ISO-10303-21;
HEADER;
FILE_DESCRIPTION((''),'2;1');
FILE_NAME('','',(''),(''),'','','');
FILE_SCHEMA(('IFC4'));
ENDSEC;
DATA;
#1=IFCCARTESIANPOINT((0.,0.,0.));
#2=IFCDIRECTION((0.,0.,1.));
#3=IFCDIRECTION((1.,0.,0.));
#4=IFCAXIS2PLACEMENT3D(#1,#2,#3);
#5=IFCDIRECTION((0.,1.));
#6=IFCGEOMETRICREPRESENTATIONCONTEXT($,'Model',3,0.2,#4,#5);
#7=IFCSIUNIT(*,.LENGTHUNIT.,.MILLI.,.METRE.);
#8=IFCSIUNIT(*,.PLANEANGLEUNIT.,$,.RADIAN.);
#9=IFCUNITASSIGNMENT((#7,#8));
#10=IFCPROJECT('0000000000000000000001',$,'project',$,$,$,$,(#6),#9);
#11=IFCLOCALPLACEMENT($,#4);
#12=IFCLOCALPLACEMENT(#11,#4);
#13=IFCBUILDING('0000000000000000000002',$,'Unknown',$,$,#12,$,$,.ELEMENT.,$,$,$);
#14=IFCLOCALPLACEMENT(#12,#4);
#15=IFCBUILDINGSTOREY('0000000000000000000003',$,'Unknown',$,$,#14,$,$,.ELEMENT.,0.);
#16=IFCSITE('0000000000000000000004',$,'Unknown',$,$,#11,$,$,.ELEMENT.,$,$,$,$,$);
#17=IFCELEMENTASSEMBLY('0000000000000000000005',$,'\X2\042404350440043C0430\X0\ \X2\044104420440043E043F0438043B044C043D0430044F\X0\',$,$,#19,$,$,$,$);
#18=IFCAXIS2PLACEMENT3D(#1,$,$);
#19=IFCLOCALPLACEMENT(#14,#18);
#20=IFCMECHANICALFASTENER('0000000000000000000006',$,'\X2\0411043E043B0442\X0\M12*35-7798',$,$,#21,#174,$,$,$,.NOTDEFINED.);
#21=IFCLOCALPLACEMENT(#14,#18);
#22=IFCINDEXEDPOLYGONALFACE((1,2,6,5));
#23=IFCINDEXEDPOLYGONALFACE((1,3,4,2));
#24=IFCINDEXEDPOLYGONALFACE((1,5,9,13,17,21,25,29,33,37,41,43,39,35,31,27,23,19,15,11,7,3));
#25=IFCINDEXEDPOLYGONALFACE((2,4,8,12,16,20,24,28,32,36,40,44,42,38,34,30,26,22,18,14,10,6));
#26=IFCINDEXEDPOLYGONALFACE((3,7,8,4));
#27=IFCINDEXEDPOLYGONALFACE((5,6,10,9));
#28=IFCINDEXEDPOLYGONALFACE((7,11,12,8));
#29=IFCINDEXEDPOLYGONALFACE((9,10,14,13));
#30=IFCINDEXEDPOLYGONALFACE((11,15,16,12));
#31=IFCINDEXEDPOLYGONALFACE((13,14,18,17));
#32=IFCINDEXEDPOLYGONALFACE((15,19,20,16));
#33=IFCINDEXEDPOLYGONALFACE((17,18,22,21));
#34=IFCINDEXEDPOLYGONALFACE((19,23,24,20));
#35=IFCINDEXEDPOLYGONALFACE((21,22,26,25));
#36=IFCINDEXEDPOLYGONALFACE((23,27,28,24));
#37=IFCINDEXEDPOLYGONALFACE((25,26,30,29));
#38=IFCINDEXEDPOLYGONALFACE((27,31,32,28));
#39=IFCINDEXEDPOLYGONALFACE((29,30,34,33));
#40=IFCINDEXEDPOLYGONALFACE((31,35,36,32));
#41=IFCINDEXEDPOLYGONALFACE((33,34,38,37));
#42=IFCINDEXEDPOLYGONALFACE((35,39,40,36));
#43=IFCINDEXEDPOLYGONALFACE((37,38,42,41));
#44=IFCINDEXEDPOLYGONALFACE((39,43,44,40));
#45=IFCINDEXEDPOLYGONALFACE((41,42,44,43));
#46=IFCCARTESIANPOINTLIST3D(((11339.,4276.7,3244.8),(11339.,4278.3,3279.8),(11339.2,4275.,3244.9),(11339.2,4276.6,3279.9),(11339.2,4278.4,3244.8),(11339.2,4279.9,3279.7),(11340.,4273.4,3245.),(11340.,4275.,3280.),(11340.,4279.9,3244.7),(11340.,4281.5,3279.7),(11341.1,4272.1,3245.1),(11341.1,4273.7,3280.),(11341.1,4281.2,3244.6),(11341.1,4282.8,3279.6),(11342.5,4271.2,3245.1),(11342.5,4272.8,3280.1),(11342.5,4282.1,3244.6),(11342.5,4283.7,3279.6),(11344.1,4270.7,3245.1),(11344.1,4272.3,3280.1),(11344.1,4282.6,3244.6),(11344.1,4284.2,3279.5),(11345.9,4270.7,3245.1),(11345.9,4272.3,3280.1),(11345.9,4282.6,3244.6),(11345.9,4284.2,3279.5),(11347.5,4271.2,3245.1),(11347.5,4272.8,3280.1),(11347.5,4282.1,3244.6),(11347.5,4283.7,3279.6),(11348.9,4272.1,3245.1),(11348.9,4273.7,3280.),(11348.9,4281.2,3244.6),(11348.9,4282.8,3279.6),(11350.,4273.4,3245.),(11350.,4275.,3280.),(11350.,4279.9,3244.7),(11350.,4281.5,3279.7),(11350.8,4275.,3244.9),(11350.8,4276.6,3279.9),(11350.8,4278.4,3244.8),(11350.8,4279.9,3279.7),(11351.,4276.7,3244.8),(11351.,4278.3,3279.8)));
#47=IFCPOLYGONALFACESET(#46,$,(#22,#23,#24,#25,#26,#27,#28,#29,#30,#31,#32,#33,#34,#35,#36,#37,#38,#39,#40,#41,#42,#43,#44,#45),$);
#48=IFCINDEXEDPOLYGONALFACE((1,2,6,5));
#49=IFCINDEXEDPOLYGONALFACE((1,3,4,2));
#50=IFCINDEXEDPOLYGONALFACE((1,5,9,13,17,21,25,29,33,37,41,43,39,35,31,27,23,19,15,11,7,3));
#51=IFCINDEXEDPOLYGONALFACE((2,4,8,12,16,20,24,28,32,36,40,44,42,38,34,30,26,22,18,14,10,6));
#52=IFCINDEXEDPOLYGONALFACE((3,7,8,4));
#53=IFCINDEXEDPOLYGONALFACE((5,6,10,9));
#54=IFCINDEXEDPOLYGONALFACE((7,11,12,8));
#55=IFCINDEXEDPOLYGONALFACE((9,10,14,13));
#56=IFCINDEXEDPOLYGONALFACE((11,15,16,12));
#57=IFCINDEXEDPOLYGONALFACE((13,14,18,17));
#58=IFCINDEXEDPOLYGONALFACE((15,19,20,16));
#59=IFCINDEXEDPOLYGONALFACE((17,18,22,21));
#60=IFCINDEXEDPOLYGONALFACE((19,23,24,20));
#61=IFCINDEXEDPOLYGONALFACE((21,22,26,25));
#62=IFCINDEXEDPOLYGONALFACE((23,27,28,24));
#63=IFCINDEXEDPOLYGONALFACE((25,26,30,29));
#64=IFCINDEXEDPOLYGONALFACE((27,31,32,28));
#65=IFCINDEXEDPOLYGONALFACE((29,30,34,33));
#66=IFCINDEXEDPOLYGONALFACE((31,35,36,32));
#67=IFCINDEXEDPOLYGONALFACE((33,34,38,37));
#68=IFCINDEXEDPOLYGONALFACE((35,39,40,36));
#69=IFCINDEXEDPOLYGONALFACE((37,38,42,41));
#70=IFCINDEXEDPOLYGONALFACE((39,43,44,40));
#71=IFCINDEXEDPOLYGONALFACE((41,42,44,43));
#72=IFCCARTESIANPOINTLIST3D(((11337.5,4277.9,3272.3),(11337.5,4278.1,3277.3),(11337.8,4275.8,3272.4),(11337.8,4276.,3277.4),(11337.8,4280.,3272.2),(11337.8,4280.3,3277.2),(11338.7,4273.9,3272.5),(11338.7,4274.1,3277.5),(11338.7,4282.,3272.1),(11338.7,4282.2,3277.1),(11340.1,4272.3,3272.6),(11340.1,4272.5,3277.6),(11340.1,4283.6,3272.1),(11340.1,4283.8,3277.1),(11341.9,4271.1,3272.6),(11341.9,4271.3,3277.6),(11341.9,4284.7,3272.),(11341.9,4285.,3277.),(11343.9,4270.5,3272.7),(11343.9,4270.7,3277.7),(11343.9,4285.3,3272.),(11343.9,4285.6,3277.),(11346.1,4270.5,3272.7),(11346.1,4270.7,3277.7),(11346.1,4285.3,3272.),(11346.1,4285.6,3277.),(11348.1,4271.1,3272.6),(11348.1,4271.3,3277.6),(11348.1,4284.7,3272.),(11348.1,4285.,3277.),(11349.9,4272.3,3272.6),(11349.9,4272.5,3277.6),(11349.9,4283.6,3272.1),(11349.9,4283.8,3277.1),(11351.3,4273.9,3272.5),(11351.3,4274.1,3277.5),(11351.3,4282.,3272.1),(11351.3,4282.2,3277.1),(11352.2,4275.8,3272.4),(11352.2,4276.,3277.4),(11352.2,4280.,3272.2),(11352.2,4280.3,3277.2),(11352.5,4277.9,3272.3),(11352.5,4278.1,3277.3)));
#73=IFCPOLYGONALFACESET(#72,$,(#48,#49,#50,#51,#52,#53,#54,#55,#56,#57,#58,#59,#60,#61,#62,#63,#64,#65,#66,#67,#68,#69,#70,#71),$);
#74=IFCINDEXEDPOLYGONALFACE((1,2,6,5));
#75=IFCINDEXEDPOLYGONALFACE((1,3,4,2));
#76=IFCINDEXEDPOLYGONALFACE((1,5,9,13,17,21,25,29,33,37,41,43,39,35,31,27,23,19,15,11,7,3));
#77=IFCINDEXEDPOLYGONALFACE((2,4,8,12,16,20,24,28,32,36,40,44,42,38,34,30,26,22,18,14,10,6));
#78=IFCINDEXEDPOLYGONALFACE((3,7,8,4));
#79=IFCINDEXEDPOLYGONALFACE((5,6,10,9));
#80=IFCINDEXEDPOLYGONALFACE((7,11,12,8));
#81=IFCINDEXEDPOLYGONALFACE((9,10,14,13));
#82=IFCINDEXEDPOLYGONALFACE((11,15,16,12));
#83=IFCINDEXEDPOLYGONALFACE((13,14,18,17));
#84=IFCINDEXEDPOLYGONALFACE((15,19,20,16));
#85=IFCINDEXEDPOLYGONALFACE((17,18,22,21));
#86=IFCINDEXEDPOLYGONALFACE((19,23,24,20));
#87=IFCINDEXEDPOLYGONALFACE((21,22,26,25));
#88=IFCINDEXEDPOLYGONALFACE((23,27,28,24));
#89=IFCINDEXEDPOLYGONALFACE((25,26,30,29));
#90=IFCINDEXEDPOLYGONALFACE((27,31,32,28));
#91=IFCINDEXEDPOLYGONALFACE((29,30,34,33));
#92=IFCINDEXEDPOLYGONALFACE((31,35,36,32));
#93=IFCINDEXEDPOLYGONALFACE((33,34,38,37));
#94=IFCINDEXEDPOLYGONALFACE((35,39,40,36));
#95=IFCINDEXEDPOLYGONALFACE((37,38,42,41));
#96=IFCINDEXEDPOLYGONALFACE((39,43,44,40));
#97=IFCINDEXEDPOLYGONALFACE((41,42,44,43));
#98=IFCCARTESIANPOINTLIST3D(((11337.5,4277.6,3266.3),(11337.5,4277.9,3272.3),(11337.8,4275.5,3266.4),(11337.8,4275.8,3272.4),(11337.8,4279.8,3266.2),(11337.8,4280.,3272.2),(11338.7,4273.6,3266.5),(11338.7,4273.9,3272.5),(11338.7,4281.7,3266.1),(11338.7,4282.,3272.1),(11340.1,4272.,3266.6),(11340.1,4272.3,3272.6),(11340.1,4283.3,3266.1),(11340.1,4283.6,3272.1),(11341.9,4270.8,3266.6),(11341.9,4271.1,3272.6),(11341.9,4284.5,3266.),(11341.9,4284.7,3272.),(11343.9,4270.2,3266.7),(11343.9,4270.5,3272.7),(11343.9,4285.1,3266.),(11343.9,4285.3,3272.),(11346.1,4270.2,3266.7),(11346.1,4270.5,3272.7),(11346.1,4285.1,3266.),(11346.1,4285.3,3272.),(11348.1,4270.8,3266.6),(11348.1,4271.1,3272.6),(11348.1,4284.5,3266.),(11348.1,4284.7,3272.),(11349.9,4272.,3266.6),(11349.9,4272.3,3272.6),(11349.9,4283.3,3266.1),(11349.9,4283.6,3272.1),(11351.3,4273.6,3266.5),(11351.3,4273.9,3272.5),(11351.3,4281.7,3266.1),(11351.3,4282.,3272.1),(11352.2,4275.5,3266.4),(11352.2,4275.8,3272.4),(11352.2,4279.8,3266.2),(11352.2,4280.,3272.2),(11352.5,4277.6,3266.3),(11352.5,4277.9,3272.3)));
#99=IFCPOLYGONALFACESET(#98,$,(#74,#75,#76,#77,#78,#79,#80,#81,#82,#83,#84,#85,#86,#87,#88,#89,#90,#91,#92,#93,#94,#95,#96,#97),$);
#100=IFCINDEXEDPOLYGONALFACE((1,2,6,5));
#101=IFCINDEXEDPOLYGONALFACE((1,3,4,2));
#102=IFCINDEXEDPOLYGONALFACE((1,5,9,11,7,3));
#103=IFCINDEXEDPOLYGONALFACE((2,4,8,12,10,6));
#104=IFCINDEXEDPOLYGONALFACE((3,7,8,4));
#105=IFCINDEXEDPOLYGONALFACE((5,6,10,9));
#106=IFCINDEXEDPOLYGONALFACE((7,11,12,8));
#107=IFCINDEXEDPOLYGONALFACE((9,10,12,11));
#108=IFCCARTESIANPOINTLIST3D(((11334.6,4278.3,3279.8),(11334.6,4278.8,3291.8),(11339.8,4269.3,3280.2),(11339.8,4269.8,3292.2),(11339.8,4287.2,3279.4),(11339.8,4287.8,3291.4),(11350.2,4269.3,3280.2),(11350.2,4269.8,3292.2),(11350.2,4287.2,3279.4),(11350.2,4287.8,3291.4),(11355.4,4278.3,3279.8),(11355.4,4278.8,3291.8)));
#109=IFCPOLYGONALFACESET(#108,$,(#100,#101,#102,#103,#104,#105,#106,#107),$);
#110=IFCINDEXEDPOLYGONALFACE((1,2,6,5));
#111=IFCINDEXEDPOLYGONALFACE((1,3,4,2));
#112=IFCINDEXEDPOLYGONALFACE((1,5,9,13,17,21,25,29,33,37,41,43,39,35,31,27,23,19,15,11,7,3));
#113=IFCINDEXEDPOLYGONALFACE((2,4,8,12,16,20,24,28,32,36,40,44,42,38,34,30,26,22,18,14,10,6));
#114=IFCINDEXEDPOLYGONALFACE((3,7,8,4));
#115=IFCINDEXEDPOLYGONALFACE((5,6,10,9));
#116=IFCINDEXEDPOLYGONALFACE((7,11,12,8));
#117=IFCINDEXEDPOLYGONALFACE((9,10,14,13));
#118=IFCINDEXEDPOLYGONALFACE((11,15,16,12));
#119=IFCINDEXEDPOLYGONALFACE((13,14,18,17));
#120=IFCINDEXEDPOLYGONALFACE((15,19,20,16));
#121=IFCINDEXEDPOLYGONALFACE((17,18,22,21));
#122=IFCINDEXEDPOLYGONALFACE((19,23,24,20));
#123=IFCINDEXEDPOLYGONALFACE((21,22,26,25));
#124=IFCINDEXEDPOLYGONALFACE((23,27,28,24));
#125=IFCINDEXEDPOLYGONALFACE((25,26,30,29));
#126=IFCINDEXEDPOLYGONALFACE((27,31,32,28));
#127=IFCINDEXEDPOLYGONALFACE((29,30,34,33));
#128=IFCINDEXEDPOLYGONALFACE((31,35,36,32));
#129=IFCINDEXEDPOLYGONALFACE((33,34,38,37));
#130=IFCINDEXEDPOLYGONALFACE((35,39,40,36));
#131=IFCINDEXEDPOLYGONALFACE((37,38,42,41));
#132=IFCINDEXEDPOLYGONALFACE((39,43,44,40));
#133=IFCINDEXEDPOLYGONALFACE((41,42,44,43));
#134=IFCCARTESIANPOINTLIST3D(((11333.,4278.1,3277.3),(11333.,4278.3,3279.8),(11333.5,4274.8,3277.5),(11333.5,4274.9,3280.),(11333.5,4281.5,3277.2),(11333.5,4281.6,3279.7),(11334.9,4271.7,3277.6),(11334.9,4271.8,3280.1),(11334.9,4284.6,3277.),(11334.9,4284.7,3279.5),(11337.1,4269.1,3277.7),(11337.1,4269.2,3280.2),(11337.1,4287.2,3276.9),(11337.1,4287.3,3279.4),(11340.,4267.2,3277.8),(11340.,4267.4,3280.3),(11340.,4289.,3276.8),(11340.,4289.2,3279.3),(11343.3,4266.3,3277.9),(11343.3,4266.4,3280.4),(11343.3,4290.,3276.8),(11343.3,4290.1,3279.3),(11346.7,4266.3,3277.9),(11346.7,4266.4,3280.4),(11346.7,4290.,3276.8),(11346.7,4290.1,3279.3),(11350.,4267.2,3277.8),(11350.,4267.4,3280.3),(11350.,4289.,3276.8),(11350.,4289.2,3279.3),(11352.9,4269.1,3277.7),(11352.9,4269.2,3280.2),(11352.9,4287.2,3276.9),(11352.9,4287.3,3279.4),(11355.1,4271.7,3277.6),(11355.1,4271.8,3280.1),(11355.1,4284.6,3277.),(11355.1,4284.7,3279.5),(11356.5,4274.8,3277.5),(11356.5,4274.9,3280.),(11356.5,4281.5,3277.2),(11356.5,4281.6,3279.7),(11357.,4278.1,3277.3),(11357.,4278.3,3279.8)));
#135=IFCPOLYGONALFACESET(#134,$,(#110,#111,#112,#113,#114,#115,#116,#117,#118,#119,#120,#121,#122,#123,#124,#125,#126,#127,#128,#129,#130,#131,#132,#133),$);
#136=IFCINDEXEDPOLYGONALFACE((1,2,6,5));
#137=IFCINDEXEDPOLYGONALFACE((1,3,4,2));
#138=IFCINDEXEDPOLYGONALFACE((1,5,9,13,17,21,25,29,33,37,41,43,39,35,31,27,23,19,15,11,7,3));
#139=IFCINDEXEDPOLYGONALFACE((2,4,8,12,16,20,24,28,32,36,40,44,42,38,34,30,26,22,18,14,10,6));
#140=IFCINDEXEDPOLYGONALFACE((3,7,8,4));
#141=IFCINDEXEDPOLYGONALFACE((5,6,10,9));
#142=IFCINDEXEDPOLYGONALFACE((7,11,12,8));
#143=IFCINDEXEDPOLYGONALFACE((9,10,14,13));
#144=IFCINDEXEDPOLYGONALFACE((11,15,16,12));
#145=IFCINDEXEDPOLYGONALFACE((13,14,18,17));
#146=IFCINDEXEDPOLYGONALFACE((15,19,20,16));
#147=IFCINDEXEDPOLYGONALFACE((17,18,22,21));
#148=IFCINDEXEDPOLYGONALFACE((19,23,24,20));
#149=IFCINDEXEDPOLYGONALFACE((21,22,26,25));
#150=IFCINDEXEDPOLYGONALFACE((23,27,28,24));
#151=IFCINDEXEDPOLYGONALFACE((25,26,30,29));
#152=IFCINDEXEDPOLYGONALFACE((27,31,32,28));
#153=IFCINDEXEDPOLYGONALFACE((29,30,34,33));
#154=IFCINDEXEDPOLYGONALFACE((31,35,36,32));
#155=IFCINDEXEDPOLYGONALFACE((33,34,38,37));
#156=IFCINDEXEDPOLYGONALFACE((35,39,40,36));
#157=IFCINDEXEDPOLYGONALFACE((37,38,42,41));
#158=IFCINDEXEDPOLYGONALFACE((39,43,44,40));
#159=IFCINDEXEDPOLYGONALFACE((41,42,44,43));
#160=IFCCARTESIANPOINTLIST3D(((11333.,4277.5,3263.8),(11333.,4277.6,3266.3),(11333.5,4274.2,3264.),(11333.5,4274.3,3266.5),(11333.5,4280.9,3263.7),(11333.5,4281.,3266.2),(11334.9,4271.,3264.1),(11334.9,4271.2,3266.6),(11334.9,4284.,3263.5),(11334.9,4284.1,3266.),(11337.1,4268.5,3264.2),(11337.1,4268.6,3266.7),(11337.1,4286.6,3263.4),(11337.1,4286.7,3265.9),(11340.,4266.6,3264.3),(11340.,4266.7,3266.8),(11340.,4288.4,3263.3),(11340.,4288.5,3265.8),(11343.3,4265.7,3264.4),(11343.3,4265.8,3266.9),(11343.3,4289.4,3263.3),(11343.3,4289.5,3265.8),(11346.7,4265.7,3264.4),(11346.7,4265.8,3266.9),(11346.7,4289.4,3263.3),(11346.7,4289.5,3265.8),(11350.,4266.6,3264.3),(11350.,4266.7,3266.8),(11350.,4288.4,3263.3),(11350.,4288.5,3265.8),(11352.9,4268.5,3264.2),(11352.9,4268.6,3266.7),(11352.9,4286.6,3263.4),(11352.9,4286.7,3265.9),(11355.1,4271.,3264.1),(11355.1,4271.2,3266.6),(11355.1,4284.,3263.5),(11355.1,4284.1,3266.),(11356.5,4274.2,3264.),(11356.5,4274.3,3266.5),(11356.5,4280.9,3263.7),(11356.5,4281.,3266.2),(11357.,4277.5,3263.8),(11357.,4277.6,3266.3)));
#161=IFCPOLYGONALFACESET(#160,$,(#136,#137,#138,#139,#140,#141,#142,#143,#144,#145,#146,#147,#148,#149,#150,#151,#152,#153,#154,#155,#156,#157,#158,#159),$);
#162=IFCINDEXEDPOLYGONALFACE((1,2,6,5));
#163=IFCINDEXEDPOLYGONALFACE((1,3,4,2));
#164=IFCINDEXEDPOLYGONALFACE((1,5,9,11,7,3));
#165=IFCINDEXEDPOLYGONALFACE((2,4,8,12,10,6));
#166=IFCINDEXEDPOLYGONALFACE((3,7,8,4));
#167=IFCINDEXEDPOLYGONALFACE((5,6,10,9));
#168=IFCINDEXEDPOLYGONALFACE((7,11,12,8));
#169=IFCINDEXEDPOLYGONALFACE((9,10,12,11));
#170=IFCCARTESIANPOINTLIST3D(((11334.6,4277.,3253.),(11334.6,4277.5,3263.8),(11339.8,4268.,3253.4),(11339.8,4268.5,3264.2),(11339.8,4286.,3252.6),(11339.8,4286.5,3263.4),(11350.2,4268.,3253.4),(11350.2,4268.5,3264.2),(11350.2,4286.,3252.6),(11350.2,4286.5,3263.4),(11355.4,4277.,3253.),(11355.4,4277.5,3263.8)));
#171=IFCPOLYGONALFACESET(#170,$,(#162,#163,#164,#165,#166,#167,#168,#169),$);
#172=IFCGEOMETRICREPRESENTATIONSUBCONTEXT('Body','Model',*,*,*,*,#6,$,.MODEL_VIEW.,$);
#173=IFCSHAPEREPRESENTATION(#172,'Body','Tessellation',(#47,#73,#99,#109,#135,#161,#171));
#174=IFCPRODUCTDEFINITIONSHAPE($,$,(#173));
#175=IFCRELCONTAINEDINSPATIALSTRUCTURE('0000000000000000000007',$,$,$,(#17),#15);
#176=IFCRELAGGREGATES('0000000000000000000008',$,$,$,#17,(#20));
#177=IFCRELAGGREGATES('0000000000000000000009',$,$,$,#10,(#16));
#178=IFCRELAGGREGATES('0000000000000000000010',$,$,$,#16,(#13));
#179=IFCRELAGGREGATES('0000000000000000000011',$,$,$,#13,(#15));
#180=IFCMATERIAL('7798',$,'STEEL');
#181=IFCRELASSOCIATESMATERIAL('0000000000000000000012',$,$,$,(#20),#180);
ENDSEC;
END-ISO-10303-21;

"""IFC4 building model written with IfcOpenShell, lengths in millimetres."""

from ifc_helpers import new_model, si_unit, direction, frame, origin_with_axes, place, context, subcontext, project, spatial, line, arc, indexed_curve, outline, extrude, source, transform, mapped, material, element, aggregate, save


model = new_model("IFC4")

# Units and contexts
model_context = context("Model", 3, precision=0.2, world=origin_with_axes(), true_north=direction((0.0, 1.0)))
body_context = subcontext(model_context, "Body", "Model", "MODEL_VIEW")
ifc_project = project(units=[si_unit("LENGTHUNIT", "METRE", prefix="MILLI"), si_unit("PLANEANGLEUNIT", "RADIAN")], contexts=[model_context])

# Site, building, storey
site_placement = place(None, origin_with_axes())
site = spatial("IfcSite", under=ifc_project, at=site_placement, Name="Unknown", CompositionType="ELEMENT")
building_placement = place(site_placement, origin_with_axes())
building = spatial("IfcBuilding", under=site, at=building_placement, Name="Unknown", CompositionType="ELEMENT")
storey_placement = place(building_placement, origin_with_axes())
storey = spatial("IfcBuildingStorey", under=building, at=storey_placement, Name="Unknown", CompositionType="ELEMENT", Elevation=0.0)

# Element assembly
assembly_1_placement = place(storey_placement, frame((11400.0, 88.6, 3426.7), z_axis=(1.0, 0.0, 0.0), x_axis=(0.0, 0.998969, -0.045408)))
assembly_1 = element("IfcElementAssembly", 1, at=assembly_1_placement, inside=storey, Name="Ферма стропильная")

# Mechanical fastener
ifc_material_1 = material(Name="7798", Category="STEEL")
shared_shape_1 = source(origin_with_axes(), body_context, "Body", "SweptSolid", [
    extrude(outline(indexed_curve([(6.0, 0.0), (0.0, 6.0), (-6.0, 0.0), (0.0, -6.0)], segments=[arc(1, 2, 3), arc(3, 4, 1)])), frame((0.0, 0.0, 7.5), z_axis=(0.0, 0.0, -1.0), x_axis=(0.0, 1.0, 0.0)), (0.0, 0.0, 1.0), 35.0),
    extrude(outline(indexed_curve([(7.5, 0.0), (0.0, 7.5), (-7.5, 0.0), (0.0, -7.5)], segments=[arc(1, 2, 3), arc(3, 4, 1)])), frame((0.0, 0.0, 5.0), z_axis=(0.0, 0.0, -1.0), x_axis=(0.0, 1.0, 0.0)), (0.0, 0.0, 1.0), 5.0),
    extrude(outline(indexed_curve([(7.5, 0.0), (0.0, 7.5), (-7.5, 0.0), (0.0, -7.5)], segments=[arc(1, 2, 3), arc(3, 4, 1)])), frame((0.0, 0.0, 0.0), z_axis=(0.0, 0.0, -1.0), x_axis=(0.0, 1.0, 0.0)), (0.0, 0.0, 1.0), 6.0),
    extrude(outline(indexed_curve([(10.4, 0.0), (5.2, 9.0), (-5.2, 9.0), (-10.4, 0.0), (-5.2, -9.0), (5.2, -9.0)], segments=[line(1, 2, 3, 4, 5, 6, 1)])), frame((0.0, 0.0, 19.5), z_axis=(0.0, 0.0, -1.0), x_axis=(0.0, 1.0, 0.0)), (0.0, 0.0, 1.0), 12.0),
    extrude(outline(indexed_curve([(12.0, 0.0), (0.0, 12.0), (-12.0, 0.0), (0.0, -12.0)], segments=[arc(1, 2, 3), arc(3, 4, 1)])), frame((0.0, 0.0, 7.5), z_axis=(0.0, 0.0, -1.0), x_axis=(0.0, 1.0, 0.0)), (0.0, 0.0, 1.0), 2.5),
    extrude(outline(indexed_curve([(12.0, 0.0), (0.0, 12.0), (-12.0, 0.0), (0.0, -12.0)], segments=[arc(1, 2, 3), arc(3, 4, 1)])), frame((0.0, 0.0, -6.0), z_axis=(0.0, 0.0, -1.0), x_axis=(0.0, 1.0, 0.0)), (0.0, 0.0, 1.0), 2.5),
    extrude(outline(indexed_curve([(10.4, 0.0), (5.2, 9.0), (-5.2, 9.0), (-10.4, 0.0), (-5.2, -9.0), (5.2, -9.0)], segments=[line(1, 2, 3, 4, 5, 6, 1)])), frame((0.0, 0.0, -8.5), z_axis=(0.0, 0.0, -1.0), x_axis=(0.0, 1.0, 0.0)), (0.0, 0.0, 1.0), 10.8),
])
mechanical_fastener_1_placement = place(assembly_1_placement, frame((4192.0, 36.0, -55.0), z_axis=(0.0, 1.0, 0.0), x_axis=(-1.0, 0.0, 0.0)))
mechanical_fastener_1 = element("IfcMechanicalFastener", 2, at=mechanical_fastener_1_placement, material=ifc_material_1, Name="БолтM12*35-7798", PredefinedType="NOTDEFINED", context=body_context, shape_type="MappedRepresentation", body=[
    mapped(shared_shape_1, transform((0.0, 0.0, 0.0))),
])
aggregate(assembly_1, [mechanical_fastener_1])

save(model, "model.ifc")
